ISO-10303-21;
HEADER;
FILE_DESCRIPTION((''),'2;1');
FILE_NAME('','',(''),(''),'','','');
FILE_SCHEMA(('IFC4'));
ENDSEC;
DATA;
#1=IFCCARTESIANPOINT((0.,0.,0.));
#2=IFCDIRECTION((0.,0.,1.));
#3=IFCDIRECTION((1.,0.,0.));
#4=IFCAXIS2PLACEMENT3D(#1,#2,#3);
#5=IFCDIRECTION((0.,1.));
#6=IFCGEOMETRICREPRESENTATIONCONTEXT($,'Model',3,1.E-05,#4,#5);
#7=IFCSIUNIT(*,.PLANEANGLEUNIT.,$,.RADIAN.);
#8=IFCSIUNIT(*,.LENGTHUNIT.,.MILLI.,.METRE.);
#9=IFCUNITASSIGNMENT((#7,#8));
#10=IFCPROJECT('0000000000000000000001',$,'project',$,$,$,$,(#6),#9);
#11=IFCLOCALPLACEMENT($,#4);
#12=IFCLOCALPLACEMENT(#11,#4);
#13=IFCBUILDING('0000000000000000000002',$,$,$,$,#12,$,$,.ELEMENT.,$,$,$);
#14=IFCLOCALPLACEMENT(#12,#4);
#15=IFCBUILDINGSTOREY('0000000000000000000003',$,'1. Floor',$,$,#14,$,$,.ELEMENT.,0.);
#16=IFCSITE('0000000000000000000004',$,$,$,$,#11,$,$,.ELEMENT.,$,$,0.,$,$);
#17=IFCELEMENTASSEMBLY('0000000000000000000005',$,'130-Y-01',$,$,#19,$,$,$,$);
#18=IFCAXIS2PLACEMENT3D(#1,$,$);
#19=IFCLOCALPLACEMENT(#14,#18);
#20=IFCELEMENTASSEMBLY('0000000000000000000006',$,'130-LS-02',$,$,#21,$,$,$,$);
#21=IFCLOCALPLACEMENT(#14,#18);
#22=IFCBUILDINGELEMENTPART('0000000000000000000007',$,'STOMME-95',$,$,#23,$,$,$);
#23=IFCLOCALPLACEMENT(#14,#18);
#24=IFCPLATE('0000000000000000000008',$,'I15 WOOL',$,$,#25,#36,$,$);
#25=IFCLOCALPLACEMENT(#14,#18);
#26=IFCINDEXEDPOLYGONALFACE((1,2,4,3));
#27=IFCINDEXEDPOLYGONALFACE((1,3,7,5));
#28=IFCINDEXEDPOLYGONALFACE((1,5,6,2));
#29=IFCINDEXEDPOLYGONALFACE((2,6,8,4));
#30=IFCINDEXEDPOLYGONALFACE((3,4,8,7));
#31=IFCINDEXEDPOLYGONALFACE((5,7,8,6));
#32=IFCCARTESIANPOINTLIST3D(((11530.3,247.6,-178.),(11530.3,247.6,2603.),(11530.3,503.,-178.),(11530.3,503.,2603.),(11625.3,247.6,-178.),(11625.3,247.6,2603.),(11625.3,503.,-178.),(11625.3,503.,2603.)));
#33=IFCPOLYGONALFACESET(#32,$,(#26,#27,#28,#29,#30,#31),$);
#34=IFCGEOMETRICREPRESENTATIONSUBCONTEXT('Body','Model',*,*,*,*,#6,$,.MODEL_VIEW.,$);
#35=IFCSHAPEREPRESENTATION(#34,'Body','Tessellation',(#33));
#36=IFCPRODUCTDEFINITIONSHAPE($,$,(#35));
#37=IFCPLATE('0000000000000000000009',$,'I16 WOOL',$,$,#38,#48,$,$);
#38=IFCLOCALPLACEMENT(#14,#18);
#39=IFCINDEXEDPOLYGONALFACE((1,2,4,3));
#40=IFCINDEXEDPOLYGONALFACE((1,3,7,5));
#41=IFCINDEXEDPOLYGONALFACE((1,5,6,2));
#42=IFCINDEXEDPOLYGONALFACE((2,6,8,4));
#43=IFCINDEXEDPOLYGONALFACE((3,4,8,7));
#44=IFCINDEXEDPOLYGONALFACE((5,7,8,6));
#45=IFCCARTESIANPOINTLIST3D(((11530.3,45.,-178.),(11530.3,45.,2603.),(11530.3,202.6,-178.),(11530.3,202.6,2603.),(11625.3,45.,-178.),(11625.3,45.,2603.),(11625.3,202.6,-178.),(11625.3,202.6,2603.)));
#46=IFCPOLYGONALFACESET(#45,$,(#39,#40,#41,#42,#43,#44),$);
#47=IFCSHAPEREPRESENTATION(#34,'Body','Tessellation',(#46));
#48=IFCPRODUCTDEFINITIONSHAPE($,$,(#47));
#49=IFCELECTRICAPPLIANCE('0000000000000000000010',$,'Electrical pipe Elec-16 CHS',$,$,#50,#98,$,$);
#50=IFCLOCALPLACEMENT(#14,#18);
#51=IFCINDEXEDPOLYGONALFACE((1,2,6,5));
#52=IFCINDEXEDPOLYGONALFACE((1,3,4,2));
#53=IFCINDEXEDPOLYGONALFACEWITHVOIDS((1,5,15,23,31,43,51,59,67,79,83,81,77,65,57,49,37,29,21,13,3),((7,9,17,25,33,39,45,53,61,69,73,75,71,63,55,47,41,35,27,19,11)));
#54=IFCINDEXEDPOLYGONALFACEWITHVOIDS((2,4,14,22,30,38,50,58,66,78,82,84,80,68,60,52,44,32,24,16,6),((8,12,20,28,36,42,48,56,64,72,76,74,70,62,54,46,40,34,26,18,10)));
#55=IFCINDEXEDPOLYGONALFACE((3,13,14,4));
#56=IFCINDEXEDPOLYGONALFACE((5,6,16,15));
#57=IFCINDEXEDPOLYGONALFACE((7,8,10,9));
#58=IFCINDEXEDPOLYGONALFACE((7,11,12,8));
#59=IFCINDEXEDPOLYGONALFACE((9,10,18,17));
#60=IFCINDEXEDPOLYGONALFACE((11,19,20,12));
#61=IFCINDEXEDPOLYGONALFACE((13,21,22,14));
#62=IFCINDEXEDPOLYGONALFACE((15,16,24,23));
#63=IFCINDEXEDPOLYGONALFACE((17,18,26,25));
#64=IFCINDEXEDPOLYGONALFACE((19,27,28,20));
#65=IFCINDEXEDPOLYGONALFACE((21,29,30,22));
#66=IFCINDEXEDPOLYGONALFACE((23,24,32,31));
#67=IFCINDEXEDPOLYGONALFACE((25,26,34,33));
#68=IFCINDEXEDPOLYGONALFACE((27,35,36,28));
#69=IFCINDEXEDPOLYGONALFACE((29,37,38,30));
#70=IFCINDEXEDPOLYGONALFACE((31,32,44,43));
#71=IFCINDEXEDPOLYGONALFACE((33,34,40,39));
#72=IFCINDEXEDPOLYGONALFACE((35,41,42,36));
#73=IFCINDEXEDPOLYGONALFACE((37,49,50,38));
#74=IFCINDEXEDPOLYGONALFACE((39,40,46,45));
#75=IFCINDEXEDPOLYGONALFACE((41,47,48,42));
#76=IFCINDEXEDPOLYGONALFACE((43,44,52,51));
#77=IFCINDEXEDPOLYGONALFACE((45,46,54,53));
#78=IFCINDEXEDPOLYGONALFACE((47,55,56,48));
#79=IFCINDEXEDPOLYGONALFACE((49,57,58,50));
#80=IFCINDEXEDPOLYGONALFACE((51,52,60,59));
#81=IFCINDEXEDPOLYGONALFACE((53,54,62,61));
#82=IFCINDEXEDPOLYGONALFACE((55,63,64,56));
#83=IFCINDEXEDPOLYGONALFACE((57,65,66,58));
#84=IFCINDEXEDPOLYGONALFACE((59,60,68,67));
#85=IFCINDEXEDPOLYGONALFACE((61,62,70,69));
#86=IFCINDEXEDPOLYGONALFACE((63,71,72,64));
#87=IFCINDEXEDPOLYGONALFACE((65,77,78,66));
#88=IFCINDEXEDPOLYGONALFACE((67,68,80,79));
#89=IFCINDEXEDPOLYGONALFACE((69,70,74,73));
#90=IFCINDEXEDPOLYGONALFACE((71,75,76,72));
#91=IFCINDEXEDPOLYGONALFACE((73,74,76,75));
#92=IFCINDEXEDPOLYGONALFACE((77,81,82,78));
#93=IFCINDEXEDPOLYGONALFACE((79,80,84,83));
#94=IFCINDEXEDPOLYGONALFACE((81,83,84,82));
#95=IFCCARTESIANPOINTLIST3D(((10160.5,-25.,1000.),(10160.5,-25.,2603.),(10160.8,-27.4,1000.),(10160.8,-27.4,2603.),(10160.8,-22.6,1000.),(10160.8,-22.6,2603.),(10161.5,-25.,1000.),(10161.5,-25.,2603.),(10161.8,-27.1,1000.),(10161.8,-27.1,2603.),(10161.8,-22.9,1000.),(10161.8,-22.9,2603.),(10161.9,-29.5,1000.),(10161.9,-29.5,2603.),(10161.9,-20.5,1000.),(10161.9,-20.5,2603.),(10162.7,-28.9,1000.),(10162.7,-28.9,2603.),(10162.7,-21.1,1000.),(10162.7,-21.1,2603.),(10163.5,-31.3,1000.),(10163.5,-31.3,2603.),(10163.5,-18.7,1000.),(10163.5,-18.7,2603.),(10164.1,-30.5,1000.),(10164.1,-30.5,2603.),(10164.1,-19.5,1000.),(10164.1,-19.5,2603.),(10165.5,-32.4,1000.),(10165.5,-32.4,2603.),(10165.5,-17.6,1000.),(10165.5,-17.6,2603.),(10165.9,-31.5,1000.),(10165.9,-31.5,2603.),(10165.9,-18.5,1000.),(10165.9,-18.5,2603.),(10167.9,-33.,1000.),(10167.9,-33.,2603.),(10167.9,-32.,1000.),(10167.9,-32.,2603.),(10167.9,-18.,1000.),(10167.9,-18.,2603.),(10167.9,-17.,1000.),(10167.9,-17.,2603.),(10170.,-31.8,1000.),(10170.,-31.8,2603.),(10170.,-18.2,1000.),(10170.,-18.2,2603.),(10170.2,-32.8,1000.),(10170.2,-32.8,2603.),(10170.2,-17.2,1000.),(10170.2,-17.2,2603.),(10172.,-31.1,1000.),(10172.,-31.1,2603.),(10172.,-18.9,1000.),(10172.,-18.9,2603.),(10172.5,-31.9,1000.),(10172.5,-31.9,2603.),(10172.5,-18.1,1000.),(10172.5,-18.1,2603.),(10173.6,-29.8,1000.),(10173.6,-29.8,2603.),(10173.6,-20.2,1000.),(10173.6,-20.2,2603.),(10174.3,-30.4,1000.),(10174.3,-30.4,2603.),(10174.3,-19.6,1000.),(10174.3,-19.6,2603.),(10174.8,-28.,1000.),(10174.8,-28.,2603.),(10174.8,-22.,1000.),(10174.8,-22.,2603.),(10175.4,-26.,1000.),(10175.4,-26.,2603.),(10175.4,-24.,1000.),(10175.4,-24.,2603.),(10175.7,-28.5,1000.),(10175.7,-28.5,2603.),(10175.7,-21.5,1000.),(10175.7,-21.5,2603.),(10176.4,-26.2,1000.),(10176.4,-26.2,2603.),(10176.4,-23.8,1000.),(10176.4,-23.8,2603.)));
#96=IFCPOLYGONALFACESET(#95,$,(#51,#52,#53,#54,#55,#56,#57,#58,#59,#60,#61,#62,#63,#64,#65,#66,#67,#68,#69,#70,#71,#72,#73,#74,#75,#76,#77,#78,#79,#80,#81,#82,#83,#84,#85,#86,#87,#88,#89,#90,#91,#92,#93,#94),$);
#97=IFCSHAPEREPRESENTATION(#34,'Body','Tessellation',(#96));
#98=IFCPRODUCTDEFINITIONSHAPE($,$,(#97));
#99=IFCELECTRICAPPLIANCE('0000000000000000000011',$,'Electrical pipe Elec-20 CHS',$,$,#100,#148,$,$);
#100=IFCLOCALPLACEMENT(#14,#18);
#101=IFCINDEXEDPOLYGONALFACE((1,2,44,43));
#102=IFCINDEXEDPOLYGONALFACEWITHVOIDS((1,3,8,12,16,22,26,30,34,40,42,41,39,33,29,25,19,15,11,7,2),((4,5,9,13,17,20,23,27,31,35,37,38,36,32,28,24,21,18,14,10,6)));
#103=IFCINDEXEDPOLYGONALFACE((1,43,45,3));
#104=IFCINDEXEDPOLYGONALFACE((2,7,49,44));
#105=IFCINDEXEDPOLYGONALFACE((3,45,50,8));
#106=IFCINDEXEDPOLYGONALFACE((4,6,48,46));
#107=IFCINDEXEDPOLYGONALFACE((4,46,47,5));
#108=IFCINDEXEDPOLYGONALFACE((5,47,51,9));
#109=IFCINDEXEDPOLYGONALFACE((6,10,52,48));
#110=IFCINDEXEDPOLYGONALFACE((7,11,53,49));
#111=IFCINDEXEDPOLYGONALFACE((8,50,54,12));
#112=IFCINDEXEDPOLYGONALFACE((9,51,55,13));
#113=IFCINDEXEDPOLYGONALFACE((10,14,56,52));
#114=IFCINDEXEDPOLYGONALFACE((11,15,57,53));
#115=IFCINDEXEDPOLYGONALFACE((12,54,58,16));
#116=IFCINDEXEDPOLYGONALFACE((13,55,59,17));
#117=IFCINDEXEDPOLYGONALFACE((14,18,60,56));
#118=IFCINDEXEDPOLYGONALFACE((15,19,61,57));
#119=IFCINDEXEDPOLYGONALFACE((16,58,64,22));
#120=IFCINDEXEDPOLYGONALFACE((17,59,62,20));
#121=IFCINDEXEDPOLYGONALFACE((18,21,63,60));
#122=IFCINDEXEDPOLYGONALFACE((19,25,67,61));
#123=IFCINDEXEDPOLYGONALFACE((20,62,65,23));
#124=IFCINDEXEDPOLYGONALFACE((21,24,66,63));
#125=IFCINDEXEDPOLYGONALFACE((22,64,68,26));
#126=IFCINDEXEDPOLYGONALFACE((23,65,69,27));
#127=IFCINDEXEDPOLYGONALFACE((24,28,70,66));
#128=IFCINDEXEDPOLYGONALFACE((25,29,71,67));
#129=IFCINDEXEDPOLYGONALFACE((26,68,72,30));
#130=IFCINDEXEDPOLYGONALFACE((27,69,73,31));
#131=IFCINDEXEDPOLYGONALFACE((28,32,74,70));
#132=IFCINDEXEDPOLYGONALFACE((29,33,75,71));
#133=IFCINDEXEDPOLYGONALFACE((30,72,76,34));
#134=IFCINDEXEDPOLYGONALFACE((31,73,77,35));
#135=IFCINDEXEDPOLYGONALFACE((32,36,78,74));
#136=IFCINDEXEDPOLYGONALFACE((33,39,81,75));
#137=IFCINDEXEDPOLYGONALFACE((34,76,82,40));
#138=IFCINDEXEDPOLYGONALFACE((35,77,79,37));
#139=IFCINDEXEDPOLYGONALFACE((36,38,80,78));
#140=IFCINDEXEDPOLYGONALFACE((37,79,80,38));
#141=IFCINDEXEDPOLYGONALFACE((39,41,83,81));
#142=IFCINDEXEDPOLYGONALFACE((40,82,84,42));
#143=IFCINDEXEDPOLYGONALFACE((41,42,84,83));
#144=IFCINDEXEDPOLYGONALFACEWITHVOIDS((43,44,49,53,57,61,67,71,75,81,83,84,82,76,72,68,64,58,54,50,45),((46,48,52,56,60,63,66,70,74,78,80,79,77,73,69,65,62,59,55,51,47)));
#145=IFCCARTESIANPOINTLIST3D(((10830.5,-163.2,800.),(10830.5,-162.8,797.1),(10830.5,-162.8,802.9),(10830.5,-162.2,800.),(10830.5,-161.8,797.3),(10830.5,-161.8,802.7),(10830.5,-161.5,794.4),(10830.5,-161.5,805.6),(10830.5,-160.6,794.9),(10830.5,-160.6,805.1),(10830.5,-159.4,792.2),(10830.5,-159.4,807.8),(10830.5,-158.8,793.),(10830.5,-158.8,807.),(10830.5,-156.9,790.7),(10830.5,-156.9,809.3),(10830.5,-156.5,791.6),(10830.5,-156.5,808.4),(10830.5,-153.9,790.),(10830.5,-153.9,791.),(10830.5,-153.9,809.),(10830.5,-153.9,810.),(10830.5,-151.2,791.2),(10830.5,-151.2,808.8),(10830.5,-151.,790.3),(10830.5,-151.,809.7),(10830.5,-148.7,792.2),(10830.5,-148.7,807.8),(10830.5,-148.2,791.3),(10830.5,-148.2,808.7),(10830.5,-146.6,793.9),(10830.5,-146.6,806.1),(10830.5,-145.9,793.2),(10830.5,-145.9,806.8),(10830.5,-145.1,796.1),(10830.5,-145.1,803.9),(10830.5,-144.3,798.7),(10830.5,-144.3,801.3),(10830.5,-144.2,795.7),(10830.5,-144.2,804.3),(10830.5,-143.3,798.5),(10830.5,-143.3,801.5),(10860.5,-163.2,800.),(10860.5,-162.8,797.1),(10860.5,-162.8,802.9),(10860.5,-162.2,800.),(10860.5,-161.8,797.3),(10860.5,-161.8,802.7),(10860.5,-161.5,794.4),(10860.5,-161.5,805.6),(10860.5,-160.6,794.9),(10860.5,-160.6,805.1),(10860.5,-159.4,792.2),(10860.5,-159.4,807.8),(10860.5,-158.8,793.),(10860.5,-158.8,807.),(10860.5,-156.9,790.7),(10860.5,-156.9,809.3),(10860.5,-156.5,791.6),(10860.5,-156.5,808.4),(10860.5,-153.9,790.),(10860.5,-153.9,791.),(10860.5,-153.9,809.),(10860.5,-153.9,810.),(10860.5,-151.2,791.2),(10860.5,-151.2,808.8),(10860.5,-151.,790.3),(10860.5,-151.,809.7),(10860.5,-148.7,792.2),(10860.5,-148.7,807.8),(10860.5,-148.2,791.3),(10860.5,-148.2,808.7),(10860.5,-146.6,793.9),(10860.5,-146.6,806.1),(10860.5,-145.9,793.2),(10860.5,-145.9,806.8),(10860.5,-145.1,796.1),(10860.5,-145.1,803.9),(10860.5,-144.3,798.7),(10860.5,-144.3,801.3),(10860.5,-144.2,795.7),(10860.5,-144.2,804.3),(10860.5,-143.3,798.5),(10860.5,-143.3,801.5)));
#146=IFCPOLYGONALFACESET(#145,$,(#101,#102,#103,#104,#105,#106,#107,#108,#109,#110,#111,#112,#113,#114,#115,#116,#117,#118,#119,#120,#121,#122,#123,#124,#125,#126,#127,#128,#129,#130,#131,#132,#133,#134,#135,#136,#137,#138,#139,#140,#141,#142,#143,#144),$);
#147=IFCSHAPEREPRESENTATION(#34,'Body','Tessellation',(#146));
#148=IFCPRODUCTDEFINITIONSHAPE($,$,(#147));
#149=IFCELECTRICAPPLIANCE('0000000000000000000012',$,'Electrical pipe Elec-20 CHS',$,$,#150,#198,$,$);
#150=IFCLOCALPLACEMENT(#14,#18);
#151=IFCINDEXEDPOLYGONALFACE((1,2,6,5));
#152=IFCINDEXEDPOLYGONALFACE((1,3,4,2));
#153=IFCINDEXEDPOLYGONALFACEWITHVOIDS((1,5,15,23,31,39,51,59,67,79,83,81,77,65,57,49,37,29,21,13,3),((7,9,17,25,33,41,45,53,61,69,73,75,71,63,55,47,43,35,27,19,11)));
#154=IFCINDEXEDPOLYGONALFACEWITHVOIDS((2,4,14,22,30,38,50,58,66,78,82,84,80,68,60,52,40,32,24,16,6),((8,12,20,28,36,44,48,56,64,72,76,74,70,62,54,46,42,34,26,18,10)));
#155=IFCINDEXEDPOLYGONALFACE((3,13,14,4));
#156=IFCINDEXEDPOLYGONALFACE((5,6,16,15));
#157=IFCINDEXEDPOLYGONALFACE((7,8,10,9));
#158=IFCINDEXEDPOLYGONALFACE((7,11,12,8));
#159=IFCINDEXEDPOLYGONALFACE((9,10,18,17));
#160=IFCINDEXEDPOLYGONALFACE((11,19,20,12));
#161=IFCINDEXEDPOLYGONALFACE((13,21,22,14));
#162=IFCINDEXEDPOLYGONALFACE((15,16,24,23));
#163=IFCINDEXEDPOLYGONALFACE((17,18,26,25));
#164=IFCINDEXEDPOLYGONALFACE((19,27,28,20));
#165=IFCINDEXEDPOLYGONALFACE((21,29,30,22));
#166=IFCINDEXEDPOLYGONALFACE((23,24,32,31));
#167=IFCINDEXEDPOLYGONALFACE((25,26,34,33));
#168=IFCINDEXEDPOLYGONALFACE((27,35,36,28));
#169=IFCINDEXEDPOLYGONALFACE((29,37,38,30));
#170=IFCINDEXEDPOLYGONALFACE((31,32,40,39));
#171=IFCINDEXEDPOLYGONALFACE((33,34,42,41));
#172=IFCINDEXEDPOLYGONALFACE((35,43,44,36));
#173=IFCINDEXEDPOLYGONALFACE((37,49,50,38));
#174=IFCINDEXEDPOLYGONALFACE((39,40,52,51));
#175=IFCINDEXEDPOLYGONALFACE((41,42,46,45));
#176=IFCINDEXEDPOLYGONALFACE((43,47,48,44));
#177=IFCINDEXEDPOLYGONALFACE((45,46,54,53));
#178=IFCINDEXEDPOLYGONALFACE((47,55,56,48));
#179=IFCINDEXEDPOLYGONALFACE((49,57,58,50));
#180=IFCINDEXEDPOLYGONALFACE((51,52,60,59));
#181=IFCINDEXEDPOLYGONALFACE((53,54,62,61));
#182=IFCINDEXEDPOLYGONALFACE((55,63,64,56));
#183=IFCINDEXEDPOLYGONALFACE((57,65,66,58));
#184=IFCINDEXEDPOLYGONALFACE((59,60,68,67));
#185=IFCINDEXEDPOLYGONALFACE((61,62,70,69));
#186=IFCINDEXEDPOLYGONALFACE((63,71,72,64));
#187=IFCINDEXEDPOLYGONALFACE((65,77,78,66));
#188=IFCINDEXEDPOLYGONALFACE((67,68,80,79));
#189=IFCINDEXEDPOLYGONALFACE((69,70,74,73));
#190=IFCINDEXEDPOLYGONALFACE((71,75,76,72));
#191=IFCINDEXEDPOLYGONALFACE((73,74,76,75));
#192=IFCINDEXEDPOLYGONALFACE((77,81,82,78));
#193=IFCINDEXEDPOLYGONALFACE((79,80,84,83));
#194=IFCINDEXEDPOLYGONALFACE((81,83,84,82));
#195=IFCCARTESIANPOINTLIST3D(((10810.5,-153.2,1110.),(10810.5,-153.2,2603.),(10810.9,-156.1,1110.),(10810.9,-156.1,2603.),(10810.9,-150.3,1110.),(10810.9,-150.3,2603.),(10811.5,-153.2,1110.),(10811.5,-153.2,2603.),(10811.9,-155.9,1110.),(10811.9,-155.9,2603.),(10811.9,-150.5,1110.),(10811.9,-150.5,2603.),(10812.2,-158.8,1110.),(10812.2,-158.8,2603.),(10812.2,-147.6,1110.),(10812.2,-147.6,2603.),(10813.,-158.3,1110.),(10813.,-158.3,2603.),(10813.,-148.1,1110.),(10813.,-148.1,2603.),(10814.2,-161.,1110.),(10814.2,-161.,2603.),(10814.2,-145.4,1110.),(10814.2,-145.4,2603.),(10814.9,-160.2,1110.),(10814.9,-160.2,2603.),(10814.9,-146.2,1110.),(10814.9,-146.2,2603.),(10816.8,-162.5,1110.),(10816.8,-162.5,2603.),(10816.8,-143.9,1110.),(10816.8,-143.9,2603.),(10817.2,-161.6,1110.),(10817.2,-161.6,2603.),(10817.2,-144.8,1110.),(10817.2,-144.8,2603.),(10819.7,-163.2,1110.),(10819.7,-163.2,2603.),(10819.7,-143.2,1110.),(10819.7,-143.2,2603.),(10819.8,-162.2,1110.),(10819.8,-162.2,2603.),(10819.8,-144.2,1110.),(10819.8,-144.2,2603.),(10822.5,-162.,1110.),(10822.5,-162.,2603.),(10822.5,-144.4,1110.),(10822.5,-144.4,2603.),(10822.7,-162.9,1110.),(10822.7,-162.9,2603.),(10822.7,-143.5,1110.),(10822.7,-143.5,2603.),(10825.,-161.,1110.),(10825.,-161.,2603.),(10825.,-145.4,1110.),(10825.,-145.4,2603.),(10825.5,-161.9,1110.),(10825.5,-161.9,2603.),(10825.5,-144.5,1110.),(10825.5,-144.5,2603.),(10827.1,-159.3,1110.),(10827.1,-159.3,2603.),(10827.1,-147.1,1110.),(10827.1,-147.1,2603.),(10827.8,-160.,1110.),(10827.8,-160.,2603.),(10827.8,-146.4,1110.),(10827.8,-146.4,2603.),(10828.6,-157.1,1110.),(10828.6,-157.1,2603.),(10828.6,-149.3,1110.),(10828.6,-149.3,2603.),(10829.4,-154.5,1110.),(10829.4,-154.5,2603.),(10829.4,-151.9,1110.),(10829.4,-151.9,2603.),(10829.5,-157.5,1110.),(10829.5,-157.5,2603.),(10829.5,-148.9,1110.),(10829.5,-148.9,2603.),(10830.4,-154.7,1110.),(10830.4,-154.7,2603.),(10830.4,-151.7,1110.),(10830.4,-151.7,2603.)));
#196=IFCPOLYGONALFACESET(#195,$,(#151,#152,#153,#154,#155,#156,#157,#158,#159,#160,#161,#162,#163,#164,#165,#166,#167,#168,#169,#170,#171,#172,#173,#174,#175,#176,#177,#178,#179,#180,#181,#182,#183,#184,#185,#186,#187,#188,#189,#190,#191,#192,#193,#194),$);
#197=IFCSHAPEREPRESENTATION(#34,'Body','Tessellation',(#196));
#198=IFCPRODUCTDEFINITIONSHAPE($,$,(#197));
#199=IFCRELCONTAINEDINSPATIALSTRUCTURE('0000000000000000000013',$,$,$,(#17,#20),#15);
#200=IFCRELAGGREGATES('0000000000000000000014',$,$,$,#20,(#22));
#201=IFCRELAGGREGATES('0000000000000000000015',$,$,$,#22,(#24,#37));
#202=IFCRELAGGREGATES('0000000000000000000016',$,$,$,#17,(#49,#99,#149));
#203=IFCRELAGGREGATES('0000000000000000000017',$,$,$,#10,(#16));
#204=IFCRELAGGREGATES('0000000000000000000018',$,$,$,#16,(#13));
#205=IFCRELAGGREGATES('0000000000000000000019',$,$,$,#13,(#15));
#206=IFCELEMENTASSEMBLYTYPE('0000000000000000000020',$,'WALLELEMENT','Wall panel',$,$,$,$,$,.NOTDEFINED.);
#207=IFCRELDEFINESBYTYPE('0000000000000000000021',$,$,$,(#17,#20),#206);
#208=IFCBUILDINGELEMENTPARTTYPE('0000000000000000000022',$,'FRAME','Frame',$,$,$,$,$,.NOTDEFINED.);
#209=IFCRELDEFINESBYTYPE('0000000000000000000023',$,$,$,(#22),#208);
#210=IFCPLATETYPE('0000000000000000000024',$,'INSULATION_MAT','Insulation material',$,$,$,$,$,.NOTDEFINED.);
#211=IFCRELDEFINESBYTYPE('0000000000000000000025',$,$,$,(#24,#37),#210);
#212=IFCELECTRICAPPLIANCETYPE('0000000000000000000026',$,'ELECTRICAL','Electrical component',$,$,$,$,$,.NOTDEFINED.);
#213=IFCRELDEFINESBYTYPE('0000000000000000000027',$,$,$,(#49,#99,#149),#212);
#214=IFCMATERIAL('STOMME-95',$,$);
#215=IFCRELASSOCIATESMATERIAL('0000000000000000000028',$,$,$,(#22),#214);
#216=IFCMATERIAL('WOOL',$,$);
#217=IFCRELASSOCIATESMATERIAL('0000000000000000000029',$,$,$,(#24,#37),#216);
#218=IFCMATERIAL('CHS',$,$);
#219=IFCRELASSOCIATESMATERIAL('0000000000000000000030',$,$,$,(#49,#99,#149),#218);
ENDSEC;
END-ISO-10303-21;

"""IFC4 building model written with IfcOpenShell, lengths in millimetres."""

from ifc_helpers import new_model, si_unit, direction, frame, origin_with_axes, origin_2d_with_axis, place, context, subcontext, project, spatial, rectangle, hollow_circle, extrude, material, type_object, element, aggregate, save


model = new_model("IFC4")

# Units and contexts
model_context = context("Model", 3, precision=1e-05, world=origin_with_axes(), true_north=direction((0.0, 1.0)))
body_context = subcontext(model_context, "Body", "Model", "MODEL_VIEW")
ifc_project = project(units=[si_unit("PLANEANGLEUNIT", "RADIAN"), si_unit("LENGTHUNIT", "METRE", prefix="MILLI")], contexts=[model_context])

# Site, building, storey
site_placement = place(None, origin_with_axes())
site = spatial("IfcSite", under=ifc_project, at=site_placement, CompositionType="ELEMENT", RefElevation=0.0)
building_placement = place(site_placement, origin_with_axes())
building = spatial("IfcBuilding", under=site, at=building_placement, CompositionType="ELEMENT")
storey_placement = place(building_placement, origin_with_axes())
storey = spatial("IfcBuildingStorey", under=building, at=storey_placement, Name="1. Floor", CompositionType="ELEMENT", Elevation=0.0)

# Shared definitions
element_assembly_type = type_object("IfcElementAssemblyType", Name="WALLELEMENT", Description="Wall panel", PredefinedType="NOTDEFINED")

# Element assembly
assembly_1_placement = place(storey_placement, origin_with_axes())
assembly_1 = element("IfcElementAssembly", 1, at=assembly_1_placement, inside=storey, type_object=element_assembly_type, Name="130-Y-01")

# Element assembly, building element part
assembly_2_placement = place(storey_placement, origin_with_axes())
assembly_2 = element("IfcElementAssembly", 2, at=assembly_2_placement, inside=storey, type_object=element_assembly_type, Name="130-LS-02")
ifc_material_1 = material(Name="STOMME-95")
building_element_part_type_1 = type_object("IfcBuildingElementPartType", Name="FRAME", Description="Frame", PredefinedType="NOTDEFINED")
building_element_part_1_placement = place(storey_placement, origin_with_axes())
building_element_part_1 = element("IfcBuildingElementPart", 3, at=building_element_part_1_placement, type_object=building_element_part_type_1, material=ifc_material_1, Name="STOMME-95")
aggregate(assembly_2, [building_element_part_1])

# Shared definitions
plate_type_1 = type_object("IfcPlateType", Name="INSULATION_MAT", Description="Insulation material", PredefinedType="NOTDEFINED")

# Shared definitions
ifc_material_2 = material(Name="WOOL")

# Plates
plate_1_placement = place(storey_placement, frame((11625.3, 375.3, 1212.5), z_axis=(1.0, 0.0, 0.0), x_axis=(0.0, 1.0, 0.0)))
plate_1 = element("IfcPlate", 4, at=plate_1_placement, type_object=plate_type_1, material=ifc_material_2, Name="I15 WOOL", context=body_context, shape_type="SweptSolid", body=[
    extrude(rectangle(XDim=95.0, YDim=255.4, at=origin_2d_with_axis()), frame((0.0, -1390.5, -47.5), z_axis=(0.0, 1.0, 0.0), x_axis=(0.0, 0.0, 1.0)), (0.0, 0.0, 1.0), 2781.0),
])
plate_2_placement = place(storey_placement, frame((11625.3, 123.8, 1212.5), z_axis=(1.0, 0.0, 0.0), x_axis=(0.0, 1.0, 0.0)))
plate_2 = element("IfcPlate", 5, at=plate_2_placement, type_object=plate_type_1, material=ifc_material_2, Name="I16 WOOL", context=body_context, shape_type="SweptSolid", body=[
    extrude(rectangle(XDim=95.0, YDim=157.6, at=origin_2d_with_axis()), frame((0.0, -1390.5, -47.5), z_axis=(0.0, 1.0, 0.0), x_axis=(0.0, 0.0, 1.0)), (0.0, 0.0, 1.0), 2781.0),
])
aggregate(building_element_part_1, [plate_1, plate_2])

# Electric appliances
ifc_material_3 = material(Name="CHS")
electric_appliance_type = type_object("IfcElectricApplianceType", Name="ELECTRICAL", Description="Electrical component", PredefinedType="NOTDEFINED")
electric_appliance_1_placement = place(storey_placement, frame((10168.5, -25.0, 1000.0), z_axis=(0.0, 0.0, 1.0), x_axis=(-1.0, 0.0, 0.0)))
electric_appliance_1 = element("IfcElectricAppliance", 6, at=electric_appliance_1_placement, type_object=electric_appliance_type, material=ifc_material_3, Name="Electrical pipe Elec-16 CHS", context=body_context, shape_type="SweptSolid", body=[
    extrude(hollow_circle(Radius=8.0, WallThickness=1.0, at=origin_2d_with_axis()), origin_with_axes(), (0.0, 0.0, 1.0), 1603.0),
])
electric_appliance_2_placement = place(storey_placement, frame((10860.5, -153.2, 800.0), z_axis=(-1.0, 0.0, 0.0), x_axis=(0.0, -1.0, 0.0)))
electric_appliance_2 = element("IfcElectricAppliance", 7, at=electric_appliance_2_placement, type_object=electric_appliance_type, material=ifc_material_3, Name="Electrical pipe Elec-20 CHS", context=body_context, shape_type="SweptSolid", body=[
    extrude(hollow_circle(Radius=10.0, WallThickness=1.0, at=origin_2d_with_axis()), origin_with_axes(), (0.0, 0.0, 1.0), 30.0),
])
electric_appliance_3_placement = place(storey_placement, frame((10820.5, -153.2, 1110.0), z_axis=(0.0, 0.0, 1.0), x_axis=(-1.0, 0.0, 0.0)))
electric_appliance_3 = element("IfcElectricAppliance", 8, at=electric_appliance_3_placement, type_object=electric_appliance_type, material=ifc_material_3, Name="Electrical pipe Elec-20 CHS", context=body_context, shape_type="SweptSolid", body=[
    extrude(hollow_circle(Radius=10.0, WallThickness=1.0, at=origin_2d_with_axis()), origin_with_axes(), (0.0, 0.0, 1.0), 1493.0),
])
aggregate(assembly_1, [electric_appliance_1, electric_appliance_2, electric_appliance_3])

save(model, "model.ifc")
